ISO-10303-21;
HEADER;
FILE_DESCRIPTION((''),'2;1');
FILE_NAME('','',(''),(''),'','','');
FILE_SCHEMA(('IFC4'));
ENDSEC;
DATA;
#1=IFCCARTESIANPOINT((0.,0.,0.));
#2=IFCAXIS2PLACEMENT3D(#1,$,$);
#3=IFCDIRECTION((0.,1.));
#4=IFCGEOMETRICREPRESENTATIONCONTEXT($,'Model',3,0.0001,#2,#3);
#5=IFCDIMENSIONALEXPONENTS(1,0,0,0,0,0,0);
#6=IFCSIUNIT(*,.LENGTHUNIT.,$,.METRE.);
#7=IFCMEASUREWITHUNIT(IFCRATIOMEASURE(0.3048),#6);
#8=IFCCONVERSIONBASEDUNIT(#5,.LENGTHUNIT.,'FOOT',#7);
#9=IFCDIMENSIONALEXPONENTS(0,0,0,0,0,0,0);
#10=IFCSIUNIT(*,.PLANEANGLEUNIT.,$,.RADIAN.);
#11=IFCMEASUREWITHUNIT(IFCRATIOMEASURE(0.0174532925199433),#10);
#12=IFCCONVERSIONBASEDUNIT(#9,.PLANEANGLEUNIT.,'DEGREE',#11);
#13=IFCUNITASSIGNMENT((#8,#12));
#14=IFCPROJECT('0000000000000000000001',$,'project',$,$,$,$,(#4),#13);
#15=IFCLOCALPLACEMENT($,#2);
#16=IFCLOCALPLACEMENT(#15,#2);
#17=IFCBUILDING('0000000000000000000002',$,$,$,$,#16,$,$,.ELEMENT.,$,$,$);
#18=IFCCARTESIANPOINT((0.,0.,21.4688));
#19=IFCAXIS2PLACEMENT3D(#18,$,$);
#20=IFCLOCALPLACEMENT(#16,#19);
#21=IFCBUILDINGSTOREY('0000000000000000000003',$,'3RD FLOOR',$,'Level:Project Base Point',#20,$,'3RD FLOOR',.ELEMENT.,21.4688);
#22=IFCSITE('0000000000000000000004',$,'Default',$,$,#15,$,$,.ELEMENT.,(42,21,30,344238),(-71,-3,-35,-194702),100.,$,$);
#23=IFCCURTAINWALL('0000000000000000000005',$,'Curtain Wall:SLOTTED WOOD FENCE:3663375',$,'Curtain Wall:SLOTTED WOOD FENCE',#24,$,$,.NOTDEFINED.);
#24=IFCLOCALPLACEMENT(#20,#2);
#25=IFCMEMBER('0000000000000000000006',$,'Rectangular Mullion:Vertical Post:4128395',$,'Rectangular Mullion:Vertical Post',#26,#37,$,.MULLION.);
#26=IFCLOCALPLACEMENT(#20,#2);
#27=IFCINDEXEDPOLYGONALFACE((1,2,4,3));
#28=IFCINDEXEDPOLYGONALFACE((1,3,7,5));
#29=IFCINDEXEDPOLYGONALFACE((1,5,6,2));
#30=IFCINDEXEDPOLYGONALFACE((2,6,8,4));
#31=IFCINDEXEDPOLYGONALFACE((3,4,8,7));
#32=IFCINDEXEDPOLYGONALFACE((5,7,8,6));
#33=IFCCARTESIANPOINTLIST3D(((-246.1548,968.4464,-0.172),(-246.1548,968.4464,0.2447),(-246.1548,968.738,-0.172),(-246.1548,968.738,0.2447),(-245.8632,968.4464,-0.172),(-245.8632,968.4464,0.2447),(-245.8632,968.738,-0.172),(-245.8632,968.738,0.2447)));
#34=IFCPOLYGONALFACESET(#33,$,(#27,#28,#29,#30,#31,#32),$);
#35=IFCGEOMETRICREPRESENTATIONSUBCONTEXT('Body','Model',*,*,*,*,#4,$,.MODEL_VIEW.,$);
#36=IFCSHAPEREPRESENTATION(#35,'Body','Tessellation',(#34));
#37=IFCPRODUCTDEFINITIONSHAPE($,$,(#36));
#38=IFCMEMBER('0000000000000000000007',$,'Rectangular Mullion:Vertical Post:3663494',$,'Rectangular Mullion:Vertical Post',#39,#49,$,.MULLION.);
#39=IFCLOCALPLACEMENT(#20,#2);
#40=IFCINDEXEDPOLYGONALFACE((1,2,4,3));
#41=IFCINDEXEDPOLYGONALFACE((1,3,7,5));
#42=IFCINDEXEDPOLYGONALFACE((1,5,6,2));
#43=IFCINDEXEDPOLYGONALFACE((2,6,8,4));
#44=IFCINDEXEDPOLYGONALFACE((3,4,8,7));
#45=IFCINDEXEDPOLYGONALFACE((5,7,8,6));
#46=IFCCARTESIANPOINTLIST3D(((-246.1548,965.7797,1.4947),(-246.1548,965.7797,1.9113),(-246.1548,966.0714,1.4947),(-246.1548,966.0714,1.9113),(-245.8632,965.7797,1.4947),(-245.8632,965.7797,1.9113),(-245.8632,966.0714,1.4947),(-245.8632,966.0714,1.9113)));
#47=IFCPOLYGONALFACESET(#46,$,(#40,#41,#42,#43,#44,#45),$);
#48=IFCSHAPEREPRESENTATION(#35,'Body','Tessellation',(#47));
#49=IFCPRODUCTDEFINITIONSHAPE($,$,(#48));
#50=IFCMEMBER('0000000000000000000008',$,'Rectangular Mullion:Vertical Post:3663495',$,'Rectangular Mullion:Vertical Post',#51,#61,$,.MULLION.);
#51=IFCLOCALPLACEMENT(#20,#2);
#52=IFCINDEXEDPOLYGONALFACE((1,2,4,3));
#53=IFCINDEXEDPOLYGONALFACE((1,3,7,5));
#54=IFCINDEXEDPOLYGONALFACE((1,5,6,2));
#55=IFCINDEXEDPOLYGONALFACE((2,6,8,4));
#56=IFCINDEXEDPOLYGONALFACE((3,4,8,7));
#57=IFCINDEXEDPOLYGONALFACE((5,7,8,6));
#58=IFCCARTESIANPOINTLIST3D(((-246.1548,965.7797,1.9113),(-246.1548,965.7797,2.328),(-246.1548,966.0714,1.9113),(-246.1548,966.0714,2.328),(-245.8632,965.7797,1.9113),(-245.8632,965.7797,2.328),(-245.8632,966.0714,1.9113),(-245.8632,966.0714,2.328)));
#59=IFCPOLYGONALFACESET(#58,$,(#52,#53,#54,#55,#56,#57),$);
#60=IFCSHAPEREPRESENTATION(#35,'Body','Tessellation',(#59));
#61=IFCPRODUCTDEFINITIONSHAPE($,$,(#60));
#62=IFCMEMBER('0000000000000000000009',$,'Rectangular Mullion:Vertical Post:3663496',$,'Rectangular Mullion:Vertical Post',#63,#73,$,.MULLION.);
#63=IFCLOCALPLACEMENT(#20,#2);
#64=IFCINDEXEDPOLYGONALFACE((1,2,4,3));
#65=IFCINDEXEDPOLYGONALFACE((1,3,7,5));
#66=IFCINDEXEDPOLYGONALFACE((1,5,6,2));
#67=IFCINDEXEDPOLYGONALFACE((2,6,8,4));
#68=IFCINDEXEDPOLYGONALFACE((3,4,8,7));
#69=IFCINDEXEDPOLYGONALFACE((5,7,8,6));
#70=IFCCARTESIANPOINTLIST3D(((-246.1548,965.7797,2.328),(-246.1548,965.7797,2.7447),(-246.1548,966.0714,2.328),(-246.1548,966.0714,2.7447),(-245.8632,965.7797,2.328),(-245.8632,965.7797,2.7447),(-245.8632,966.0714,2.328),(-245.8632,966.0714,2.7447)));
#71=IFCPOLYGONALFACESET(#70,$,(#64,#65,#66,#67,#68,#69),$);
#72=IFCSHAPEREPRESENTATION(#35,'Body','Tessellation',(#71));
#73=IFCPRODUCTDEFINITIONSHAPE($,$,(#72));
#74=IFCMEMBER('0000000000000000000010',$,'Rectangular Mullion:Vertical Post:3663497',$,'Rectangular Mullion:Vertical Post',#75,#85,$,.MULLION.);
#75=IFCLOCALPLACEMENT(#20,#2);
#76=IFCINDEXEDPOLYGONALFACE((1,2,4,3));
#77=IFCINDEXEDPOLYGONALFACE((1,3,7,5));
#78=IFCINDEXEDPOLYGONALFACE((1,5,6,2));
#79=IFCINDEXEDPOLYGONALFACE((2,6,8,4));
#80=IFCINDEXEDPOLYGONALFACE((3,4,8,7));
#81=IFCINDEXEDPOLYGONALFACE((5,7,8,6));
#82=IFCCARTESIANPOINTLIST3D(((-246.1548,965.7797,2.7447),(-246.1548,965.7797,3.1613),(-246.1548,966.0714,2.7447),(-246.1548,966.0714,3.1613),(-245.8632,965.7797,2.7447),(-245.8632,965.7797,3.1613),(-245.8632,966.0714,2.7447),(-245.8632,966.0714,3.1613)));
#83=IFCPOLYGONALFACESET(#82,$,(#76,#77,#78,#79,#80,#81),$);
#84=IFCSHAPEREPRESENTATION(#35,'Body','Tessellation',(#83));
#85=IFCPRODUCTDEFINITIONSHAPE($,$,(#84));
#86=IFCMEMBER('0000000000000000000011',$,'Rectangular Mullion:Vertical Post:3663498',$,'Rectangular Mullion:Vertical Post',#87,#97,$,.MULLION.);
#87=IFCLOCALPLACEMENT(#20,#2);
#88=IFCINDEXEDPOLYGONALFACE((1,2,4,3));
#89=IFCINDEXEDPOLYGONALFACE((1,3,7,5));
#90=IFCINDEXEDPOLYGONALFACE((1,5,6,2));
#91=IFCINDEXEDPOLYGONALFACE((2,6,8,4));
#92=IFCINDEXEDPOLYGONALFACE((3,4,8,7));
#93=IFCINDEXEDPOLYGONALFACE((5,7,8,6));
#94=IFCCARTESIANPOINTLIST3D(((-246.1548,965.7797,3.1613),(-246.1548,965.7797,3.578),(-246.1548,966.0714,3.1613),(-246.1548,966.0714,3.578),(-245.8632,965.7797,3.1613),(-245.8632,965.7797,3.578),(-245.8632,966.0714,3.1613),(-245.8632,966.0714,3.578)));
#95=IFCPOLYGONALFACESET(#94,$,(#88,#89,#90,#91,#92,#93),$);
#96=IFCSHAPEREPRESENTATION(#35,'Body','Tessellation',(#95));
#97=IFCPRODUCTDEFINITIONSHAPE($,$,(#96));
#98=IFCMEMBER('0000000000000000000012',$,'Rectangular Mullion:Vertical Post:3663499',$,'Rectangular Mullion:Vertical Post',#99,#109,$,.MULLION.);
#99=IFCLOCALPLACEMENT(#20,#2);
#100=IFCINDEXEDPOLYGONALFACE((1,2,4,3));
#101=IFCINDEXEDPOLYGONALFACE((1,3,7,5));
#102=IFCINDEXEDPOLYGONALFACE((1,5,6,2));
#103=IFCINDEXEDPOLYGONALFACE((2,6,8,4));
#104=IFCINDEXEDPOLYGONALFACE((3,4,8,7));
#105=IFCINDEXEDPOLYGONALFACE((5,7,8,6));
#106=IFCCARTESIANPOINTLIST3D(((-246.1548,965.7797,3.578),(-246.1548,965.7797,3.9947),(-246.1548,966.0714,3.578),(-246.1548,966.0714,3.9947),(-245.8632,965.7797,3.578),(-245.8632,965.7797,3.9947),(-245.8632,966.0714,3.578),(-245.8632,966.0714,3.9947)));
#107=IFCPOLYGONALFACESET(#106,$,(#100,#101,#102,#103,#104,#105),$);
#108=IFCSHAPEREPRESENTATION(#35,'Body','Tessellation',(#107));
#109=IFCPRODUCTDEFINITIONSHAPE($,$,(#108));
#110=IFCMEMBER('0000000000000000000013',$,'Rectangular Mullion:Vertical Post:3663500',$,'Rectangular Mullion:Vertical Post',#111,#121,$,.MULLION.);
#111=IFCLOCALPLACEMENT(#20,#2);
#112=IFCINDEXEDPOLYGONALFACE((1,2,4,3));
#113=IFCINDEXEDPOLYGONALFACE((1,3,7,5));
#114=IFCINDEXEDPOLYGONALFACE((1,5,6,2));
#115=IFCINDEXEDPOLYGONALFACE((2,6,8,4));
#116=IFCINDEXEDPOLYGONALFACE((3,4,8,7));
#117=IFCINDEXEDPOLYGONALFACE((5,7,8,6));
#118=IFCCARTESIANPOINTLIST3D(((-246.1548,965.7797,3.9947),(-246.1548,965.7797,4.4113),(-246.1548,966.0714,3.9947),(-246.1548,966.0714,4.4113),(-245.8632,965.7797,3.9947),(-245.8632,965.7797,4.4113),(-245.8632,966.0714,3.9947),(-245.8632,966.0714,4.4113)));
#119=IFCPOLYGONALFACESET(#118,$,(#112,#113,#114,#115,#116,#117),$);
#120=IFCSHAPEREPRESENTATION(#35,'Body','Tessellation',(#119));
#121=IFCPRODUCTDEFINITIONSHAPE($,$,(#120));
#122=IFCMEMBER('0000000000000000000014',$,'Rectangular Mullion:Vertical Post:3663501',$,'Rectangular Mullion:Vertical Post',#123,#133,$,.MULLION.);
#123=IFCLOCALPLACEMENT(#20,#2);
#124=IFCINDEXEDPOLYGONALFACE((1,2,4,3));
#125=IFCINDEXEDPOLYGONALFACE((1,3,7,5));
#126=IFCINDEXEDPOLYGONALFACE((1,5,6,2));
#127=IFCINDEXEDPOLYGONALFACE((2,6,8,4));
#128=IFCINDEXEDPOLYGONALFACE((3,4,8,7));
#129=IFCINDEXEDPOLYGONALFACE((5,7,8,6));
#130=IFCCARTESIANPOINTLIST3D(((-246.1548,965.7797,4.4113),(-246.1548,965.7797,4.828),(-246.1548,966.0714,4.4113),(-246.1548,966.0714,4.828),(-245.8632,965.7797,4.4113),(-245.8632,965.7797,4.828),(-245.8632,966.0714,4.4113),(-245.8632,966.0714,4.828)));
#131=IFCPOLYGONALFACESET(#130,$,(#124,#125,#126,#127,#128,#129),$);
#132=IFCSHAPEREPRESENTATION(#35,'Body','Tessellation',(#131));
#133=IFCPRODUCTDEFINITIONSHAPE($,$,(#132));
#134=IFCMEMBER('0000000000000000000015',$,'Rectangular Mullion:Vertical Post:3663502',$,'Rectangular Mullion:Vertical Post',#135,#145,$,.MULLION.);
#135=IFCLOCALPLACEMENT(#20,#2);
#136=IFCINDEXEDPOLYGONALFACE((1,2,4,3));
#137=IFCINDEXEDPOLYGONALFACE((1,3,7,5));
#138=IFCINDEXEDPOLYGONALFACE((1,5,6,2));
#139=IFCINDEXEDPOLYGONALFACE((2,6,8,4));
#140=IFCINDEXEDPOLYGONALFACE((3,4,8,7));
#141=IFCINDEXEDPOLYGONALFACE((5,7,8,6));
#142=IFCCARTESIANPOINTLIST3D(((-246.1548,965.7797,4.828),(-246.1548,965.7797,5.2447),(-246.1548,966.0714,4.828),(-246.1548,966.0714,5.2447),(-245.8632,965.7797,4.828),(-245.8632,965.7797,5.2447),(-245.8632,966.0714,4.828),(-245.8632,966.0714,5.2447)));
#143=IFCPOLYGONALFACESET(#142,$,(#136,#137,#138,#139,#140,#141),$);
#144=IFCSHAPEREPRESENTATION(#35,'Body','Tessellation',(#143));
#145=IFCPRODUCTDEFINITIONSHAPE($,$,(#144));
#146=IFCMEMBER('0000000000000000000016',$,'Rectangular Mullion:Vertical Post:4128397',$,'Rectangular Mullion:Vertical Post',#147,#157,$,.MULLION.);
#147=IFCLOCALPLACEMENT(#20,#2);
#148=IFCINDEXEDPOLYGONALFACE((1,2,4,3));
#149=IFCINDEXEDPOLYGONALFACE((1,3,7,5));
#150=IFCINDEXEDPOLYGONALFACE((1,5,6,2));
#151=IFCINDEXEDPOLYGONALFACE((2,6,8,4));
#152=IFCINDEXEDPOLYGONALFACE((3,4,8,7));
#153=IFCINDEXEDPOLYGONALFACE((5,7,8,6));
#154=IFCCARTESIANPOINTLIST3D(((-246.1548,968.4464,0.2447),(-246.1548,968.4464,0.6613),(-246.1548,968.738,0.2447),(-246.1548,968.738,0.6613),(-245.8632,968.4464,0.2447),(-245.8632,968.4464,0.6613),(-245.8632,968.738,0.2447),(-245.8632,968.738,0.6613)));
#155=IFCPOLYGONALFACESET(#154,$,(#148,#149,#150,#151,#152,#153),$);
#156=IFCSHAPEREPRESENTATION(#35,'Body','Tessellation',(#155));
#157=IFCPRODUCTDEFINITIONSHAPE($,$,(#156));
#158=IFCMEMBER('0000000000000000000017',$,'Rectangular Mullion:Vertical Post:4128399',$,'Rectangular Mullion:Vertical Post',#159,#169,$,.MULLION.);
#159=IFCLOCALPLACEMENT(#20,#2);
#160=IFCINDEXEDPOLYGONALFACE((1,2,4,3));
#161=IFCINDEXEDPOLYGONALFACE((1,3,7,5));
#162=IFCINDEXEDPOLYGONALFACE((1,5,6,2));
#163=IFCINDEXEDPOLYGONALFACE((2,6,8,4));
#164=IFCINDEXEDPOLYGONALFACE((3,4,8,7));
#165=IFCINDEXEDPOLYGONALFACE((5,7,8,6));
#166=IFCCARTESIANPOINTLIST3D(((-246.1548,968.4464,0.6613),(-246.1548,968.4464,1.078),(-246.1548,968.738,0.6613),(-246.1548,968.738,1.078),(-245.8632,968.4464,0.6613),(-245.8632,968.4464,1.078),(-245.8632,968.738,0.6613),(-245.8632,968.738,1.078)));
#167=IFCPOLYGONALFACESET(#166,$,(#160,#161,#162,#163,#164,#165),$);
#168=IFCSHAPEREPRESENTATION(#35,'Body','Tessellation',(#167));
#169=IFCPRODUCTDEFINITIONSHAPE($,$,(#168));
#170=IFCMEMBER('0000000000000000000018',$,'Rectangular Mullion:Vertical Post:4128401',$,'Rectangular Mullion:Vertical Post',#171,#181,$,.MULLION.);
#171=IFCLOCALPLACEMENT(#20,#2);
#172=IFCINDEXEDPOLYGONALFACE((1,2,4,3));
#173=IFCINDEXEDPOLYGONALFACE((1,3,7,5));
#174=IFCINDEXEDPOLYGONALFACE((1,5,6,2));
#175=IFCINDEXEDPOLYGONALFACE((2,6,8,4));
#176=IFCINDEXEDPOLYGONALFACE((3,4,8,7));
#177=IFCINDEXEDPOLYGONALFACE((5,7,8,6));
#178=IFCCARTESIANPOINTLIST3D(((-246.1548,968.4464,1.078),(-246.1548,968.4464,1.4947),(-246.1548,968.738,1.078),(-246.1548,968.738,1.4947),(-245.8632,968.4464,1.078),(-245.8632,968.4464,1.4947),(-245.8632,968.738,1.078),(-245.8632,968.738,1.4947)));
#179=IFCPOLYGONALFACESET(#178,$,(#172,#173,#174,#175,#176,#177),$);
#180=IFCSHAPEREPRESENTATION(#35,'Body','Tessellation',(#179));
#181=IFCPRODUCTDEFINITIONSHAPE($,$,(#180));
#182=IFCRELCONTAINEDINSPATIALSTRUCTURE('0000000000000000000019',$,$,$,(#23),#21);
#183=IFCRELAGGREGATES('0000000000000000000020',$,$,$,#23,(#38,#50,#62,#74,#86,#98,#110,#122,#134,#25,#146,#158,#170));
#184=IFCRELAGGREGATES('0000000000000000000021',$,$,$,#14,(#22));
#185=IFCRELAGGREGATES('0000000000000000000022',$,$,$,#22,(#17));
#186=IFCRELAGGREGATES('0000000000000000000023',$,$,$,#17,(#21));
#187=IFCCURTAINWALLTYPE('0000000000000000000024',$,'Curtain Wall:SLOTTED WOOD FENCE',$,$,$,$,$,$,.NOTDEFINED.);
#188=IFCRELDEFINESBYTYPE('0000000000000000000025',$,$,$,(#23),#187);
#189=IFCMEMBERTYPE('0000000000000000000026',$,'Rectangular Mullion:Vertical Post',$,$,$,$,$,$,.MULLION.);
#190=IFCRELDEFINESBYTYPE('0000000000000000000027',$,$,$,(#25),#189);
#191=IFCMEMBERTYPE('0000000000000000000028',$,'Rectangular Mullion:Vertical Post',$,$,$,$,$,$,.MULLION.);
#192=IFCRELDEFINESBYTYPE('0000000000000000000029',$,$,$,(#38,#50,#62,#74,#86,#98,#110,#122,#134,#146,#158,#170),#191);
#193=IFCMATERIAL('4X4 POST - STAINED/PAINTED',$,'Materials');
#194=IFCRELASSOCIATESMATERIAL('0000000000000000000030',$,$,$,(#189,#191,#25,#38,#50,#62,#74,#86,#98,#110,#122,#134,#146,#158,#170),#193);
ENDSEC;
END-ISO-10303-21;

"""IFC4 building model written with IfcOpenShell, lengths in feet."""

from ifc_helpers import new_model, entity, si_unit, converted_unit, direction, frame, origin, origin_2d_with_axis, place, context, subcontext, project, spatial, rectangle, extrude, source, transform, mapped, material, material_profile, profile_set, profile_usage, type_object, type_shapes, element, aggregate, save


model = new_model("IFC4")

# Units and contexts
model_context = context("Model", 3, precision=0.0001, world=origin(), true_north=direction((0.0, 1.0)))
body_context = subcontext(model_context, "Body", "Model", "MODEL_VIEW")
ifc_project = project(units=[converted_unit("LENGTHUNIT", "FOOT", entity("IfcRatioMeasure", 0.3048), si_unit("LENGTHUNIT", "METRE"), dimensions=[1, 0, 0, 0, 0, 0, 0]), converted_unit("PLANEANGLEUNIT", "DEGREE", entity("IfcRatioMeasure", 0.0174532925199433), si_unit("PLANEANGLEUNIT", "RADIAN"), dimensions=[0, 0, 0, 0, 0, 0, 0])], contexts=[model_context])

# Site, building, storey
site_placement = place(None, origin())
site = spatial("IfcSite", under=ifc_project, at=site_placement, Name="Default", CompositionType="ELEMENT", RefLatitude=(42, 21, 30, 344238), RefLongitude=(-71, -3, -35, -194702), RefElevation=100.0)
building_placement = place(site_placement, origin())
building = spatial("IfcBuilding", under=site, at=building_placement, CompositionType="ELEMENT")
storey_placement = place(building_placement, frame((0.0, 0.0, 21.4688)))
storey = spatial("IfcBuildingStorey", under=building, at=storey_placement, Name="3RD FLOOR", ObjectType="Level:Project Base Point", LongName="3RD FLOOR", CompositionType="ELEMENT", Elevation=21.4688)

# Curtain wall, members
curtain_wall_type = type_object("IfcCurtainWallType", Name="Curtain Wall:SLOTTED WOOD FENCE", PredefinedType="NOTDEFINED")
curtain_wall_placement = place(storey_placement, frame((0.0, 0.0, -21.4688)))
curtain_wall = element("IfcCurtainWall", 1, at=curtain_wall_placement, inside=storey, type_object=curtain_wall_type, Name="Curtain Wall:SLOTTED WOOD FENCE:3663375", ObjectType="Curtain Wall:SLOTTED WOOD FENCE", PredefinedType="NOTDEFINED")
ifc_material = material(Name="4X4 POST - STAINED/PAINTED", Category="Materials")
ifc_material_profile = material_profile(ifc_material, rectangle(XDim=0.2917, YDim=0.2917, at=origin_2d_with_axis()), Name="Vertical Post")
ifc_profile_set = profile_set([ifc_material_profile], Name="Vertical Post")
ifc_profile_usage_1 = profile_usage(ifc_profile_set)
member_type_1 = type_object("IfcMemberType", Name="Rectangular Mullion:Vertical Post", PredefinedType="MULLION", material=ifc_profile_set)
shared_shape_1 = source(origin(), body_context, "Body", "SweptSolid", [
    extrude(rectangle(XDim=0.2917, YDim=0.2917, at=origin_2d_with_axis()), frame((0.0, 0.2083, -0.4167), z_axis=(0.0, 0.0, 1.0), x_axis=(0.0, -1.0, 0.0)), (0.0, 0.0, 1.0), 0.4167),
])
type_shapes(member_type_1, [shared_shape_1])
member_1_placement = place(storey_placement, frame((-245.8007, 968.5922, -0.172), z_axis=(0.0, 0.0, -1.0), x_axis=(0.0, -1.0, 0.0)))
member_1 = element("IfcMember", 2, at=member_1_placement, type_object=member_type_1, material=ifc_profile_usage_1, Name="Rectangular Mullion:Vertical Post:4128395", ObjectType="Rectangular Mullion:Vertical Post", PredefinedType="MULLION", context=body_context, shape_type="MappedRepresentation", body=[
    mapped(shared_shape_1, transform((0.0, 0.0, 0.0), scale=1.0)),
])
ifc_profile_usage_2 = profile_usage(ifc_profile_set)
member_type_2 = type_object("IfcMemberType", Name="Rectangular Mullion:Vertical Post", PredefinedType="MULLION", material=ifc_profile_set)
shared_shape_2 = source(origin(), body_context, "Body", "SweptSolid", [
    extrude(rectangle(XDim=0.2917, YDim=0.2917, at=origin_2d_with_axis()), frame((0.0, 0.2083, -0.4167), z_axis=(0.0, 0.0, 1.0), x_axis=(0.0, -1.0, 0.0)), (0.0, 0.0, 1.0), 0.4167),
])
type_shapes(member_type_2, [shared_shape_2])
member_2_placement = place(storey_placement, frame((-245.8007, 965.9255, 1.4947), z_axis=(0.0, 0.0, -1.0), x_axis=(0.0, -1.0, 0.0)))
member_2 = element("IfcMember", 3, at=member_2_placement, type_object=member_type_2, material=ifc_profile_usage_2, Name="Rectangular Mullion:Vertical Post:3663494", ObjectType="Rectangular Mullion:Vertical Post", PredefinedType="MULLION", context=body_context, shape_type="MappedRepresentation", body=[
    mapped(shared_shape_2, transform((0.0, 0.0, 0.0), scale=1.0)),
])
ifc_profile_usage_3 = profile_usage(ifc_profile_set)
member_3_placement = place(storey_placement, frame((-245.8007, 965.9255, 1.9113), z_axis=(0.0, 0.0, -1.0), x_axis=(0.0, -1.0, 0.0)))
member_3 = element("IfcMember", 4, at=member_3_placement, type_object=member_type_2, material=ifc_profile_usage_3, Name="Rectangular Mullion:Vertical Post:3663495", ObjectType="Rectangular Mullion:Vertical Post", PredefinedType="MULLION", context=body_context, shape_type="MappedRepresentation", body=[
    mapped(shared_shape_2, transform((0.0, 0.0, 0.0), scale=1.0)),
])
ifc_profile_usage_4 = profile_usage(ifc_profile_set)
member_4_placement = place(storey_placement, frame((-245.8007, 965.9255, 2.328), z_axis=(0.0, 0.0, -1.0), x_axis=(0.0, -1.0, 0.0)))
member_4 = element("IfcMember", 5, at=member_4_placement, type_object=member_type_2, material=ifc_profile_usage_4, Name="Rectangular Mullion:Vertical Post:3663496", ObjectType="Rectangular Mullion:Vertical Post", PredefinedType="MULLION", context=body_context, shape_type="MappedRepresentation", body=[
    mapped(shared_shape_2, transform((0.0, 0.0, 0.0), scale=1.0)),
])
ifc_profile_usage_5 = profile_usage(ifc_profile_set)
member_5_placement = place(storey_placement, frame((-245.8007, 965.9255, 2.7447), z_axis=(0.0, 0.0, -1.0), x_axis=(0.0, -1.0, 0.0)))
member_5 = element("IfcMember", 6, at=member_5_placement, type_object=member_type_2, material=ifc_profile_usage_5, Name="Rectangular Mullion:Vertical Post:3663497", ObjectType="Rectangular Mullion:Vertical Post", PredefinedType="MULLION", context=body_context, shape_type="MappedRepresentation", body=[
    mapped(shared_shape_2, transform((0.0, 0.0, 0.0), scale=1.0)),
])
ifc_profile_usage_6 = profile_usage(ifc_profile_set)
member_6_placement = place(storey_placement, frame((-245.8007, 965.9255, 3.1613), z_axis=(0.0, 0.0, -1.0), x_axis=(0.0, -1.0, 0.0)))
member_6 = element("IfcMember", 7, at=member_6_placement, type_object=member_type_2, material=ifc_profile_usage_6, Name="Rectangular Mullion:Vertical Post:3663498", ObjectType="Rectangular Mullion:Vertical Post", PredefinedType="MULLION", context=body_context, shape_type="MappedRepresentation", body=[
    mapped(shared_shape_2, transform((0.0, 0.0, 0.0), scale=1.0)),
])
ifc_profile_usage_7 = profile_usage(ifc_profile_set)
member_7_placement = place(storey_placement, frame((-245.8007, 965.9255, 3.578), z_axis=(0.0, 0.0, -1.0), x_axis=(0.0, -1.0, 0.0)))
member_7 = element("IfcMember", 8, at=member_7_placement, type_object=member_type_2, material=ifc_profile_usage_7, Name="Rectangular Mullion:Vertical Post:3663499", ObjectType="Rectangular Mullion:Vertical Post", PredefinedType="MULLION", context=body_context, shape_type="MappedRepresentation", body=[
    mapped(shared_shape_2, transform((0.0, 0.0, 0.0), scale=1.0)),
])
ifc_profile_usage_8 = profile_usage(ifc_profile_set)
member_8_placement = place(storey_placement, frame((-245.8007, 965.9255, 3.9947), z_axis=(0.0, 0.0, -1.0), x_axis=(0.0, -1.0, 0.0)))
member_8 = element("IfcMember", 9, at=member_8_placement, type_object=member_type_2, material=ifc_profile_usage_8, Name="Rectangular Mullion:Vertical Post:3663500", ObjectType="Rectangular Mullion:Vertical Post", PredefinedType="MULLION", context=body_context, shape_type="MappedRepresentation", body=[
    mapped(shared_shape_2, transform((0.0, 0.0, 0.0), scale=1.0)),
])
ifc_profile_usage_9 = profile_usage(ifc_profile_set)
member_9_placement = place(storey_placement, frame((-245.8007, 965.9255, 4.4113), z_axis=(0.0, 0.0, -1.0), x_axis=(0.0, -1.0, 0.0)))
member_9 = element("IfcMember", 10, at=member_9_placement, type_object=member_type_2, material=ifc_profile_usage_9, Name="Rectangular Mullion:Vertical Post:3663501", ObjectType="Rectangular Mullion:Vertical Post", PredefinedType="MULLION", context=body_context, shape_type="MappedRepresentation", body=[
    mapped(shared_shape_2, transform((0.0, 0.0, 0.0), scale=1.0)),
])
ifc_profile_usage_10 = profile_usage(ifc_profile_set)
member_10_placement = place(storey_placement, frame((-245.8007, 965.9255, 4.828), z_axis=(0.0, 0.0, -1.0), x_axis=(0.0, -1.0, 0.0)))
member_10 = element("IfcMember", 11, at=member_10_placement, type_object=member_type_2, material=ifc_profile_usage_10, Name="Rectangular Mullion:Vertical Post:3663502", ObjectType="Rectangular Mullion:Vertical Post", PredefinedType="MULLION", context=body_context, shape_type="MappedRepresentation", body=[
    mapped(shared_shape_2, transform((0.0, 0.0, 0.0), scale=1.0)),
])
ifc_profile_usage_11 = profile_usage(ifc_profile_set)
member_11_placement = place(storey_placement, frame((-245.8007, 968.5922, 0.2447), z_axis=(0.0, 0.0, -1.0), x_axis=(0.0, -1.0, 0.0)))
member_11 = element("IfcMember", 12, at=member_11_placement, type_object=member_type_2, material=ifc_profile_usage_11, Name="Rectangular Mullion:Vertical Post:4128397", ObjectType="Rectangular Mullion:Vertical Post", PredefinedType="MULLION", context=body_context, shape_type="MappedRepresentation", body=[
    mapped(shared_shape_2, transform((0.0, 0.0, 0.0), scale=1.0)),
])
ifc_profile_usage_12 = profile_usage(ifc_profile_set)
member_12_placement = place(storey_placement, frame((-245.8007, 968.5922, 0.6613), z_axis=(0.0, 0.0, -1.0), x_axis=(0.0, -1.0, 0.0)))
member_12 = element("IfcMember", 13, at=member_12_placement, type_object=member_type_2, material=ifc_profile_usage_12, Name="Rectangular Mullion:Vertical Post:4128399", ObjectType="Rectangular Mullion:Vertical Post", PredefinedType="MULLION", context=body_context, shape_type="MappedRepresentation", body=[
    mapped(shared_shape_2, transform((0.0, 0.0, 0.0), scale=1.0)),
])
ifc_profile_usage_13 = profile_usage(ifc_profile_set)
member_13_placement = place(storey_placement, frame((-245.8007, 968.5922, 1.078), z_axis=(0.0, 0.0, -1.0), x_axis=(0.0, -1.0, 0.0)))
member_13 = element("IfcMember", 14, at=member_13_placement, type_object=member_type_2, material=ifc_profile_usage_13, Name="Rectangular Mullion:Vertical Post:4128401", ObjectType="Rectangular Mullion:Vertical Post", PredefinedType="MULLION", context=body_context, shape_type="MappedRepresentation", body=[
    mapped(shared_shape_2, transform((0.0, 0.0, 0.0), scale=1.0)),
])
aggregate(curtain_wall, [member_2, member_3, member_4, member_5, member_6, member_7, member_8, member_9, member_10, member_1, member_11, member_12, member_13])

save(model, "model.ifc")
